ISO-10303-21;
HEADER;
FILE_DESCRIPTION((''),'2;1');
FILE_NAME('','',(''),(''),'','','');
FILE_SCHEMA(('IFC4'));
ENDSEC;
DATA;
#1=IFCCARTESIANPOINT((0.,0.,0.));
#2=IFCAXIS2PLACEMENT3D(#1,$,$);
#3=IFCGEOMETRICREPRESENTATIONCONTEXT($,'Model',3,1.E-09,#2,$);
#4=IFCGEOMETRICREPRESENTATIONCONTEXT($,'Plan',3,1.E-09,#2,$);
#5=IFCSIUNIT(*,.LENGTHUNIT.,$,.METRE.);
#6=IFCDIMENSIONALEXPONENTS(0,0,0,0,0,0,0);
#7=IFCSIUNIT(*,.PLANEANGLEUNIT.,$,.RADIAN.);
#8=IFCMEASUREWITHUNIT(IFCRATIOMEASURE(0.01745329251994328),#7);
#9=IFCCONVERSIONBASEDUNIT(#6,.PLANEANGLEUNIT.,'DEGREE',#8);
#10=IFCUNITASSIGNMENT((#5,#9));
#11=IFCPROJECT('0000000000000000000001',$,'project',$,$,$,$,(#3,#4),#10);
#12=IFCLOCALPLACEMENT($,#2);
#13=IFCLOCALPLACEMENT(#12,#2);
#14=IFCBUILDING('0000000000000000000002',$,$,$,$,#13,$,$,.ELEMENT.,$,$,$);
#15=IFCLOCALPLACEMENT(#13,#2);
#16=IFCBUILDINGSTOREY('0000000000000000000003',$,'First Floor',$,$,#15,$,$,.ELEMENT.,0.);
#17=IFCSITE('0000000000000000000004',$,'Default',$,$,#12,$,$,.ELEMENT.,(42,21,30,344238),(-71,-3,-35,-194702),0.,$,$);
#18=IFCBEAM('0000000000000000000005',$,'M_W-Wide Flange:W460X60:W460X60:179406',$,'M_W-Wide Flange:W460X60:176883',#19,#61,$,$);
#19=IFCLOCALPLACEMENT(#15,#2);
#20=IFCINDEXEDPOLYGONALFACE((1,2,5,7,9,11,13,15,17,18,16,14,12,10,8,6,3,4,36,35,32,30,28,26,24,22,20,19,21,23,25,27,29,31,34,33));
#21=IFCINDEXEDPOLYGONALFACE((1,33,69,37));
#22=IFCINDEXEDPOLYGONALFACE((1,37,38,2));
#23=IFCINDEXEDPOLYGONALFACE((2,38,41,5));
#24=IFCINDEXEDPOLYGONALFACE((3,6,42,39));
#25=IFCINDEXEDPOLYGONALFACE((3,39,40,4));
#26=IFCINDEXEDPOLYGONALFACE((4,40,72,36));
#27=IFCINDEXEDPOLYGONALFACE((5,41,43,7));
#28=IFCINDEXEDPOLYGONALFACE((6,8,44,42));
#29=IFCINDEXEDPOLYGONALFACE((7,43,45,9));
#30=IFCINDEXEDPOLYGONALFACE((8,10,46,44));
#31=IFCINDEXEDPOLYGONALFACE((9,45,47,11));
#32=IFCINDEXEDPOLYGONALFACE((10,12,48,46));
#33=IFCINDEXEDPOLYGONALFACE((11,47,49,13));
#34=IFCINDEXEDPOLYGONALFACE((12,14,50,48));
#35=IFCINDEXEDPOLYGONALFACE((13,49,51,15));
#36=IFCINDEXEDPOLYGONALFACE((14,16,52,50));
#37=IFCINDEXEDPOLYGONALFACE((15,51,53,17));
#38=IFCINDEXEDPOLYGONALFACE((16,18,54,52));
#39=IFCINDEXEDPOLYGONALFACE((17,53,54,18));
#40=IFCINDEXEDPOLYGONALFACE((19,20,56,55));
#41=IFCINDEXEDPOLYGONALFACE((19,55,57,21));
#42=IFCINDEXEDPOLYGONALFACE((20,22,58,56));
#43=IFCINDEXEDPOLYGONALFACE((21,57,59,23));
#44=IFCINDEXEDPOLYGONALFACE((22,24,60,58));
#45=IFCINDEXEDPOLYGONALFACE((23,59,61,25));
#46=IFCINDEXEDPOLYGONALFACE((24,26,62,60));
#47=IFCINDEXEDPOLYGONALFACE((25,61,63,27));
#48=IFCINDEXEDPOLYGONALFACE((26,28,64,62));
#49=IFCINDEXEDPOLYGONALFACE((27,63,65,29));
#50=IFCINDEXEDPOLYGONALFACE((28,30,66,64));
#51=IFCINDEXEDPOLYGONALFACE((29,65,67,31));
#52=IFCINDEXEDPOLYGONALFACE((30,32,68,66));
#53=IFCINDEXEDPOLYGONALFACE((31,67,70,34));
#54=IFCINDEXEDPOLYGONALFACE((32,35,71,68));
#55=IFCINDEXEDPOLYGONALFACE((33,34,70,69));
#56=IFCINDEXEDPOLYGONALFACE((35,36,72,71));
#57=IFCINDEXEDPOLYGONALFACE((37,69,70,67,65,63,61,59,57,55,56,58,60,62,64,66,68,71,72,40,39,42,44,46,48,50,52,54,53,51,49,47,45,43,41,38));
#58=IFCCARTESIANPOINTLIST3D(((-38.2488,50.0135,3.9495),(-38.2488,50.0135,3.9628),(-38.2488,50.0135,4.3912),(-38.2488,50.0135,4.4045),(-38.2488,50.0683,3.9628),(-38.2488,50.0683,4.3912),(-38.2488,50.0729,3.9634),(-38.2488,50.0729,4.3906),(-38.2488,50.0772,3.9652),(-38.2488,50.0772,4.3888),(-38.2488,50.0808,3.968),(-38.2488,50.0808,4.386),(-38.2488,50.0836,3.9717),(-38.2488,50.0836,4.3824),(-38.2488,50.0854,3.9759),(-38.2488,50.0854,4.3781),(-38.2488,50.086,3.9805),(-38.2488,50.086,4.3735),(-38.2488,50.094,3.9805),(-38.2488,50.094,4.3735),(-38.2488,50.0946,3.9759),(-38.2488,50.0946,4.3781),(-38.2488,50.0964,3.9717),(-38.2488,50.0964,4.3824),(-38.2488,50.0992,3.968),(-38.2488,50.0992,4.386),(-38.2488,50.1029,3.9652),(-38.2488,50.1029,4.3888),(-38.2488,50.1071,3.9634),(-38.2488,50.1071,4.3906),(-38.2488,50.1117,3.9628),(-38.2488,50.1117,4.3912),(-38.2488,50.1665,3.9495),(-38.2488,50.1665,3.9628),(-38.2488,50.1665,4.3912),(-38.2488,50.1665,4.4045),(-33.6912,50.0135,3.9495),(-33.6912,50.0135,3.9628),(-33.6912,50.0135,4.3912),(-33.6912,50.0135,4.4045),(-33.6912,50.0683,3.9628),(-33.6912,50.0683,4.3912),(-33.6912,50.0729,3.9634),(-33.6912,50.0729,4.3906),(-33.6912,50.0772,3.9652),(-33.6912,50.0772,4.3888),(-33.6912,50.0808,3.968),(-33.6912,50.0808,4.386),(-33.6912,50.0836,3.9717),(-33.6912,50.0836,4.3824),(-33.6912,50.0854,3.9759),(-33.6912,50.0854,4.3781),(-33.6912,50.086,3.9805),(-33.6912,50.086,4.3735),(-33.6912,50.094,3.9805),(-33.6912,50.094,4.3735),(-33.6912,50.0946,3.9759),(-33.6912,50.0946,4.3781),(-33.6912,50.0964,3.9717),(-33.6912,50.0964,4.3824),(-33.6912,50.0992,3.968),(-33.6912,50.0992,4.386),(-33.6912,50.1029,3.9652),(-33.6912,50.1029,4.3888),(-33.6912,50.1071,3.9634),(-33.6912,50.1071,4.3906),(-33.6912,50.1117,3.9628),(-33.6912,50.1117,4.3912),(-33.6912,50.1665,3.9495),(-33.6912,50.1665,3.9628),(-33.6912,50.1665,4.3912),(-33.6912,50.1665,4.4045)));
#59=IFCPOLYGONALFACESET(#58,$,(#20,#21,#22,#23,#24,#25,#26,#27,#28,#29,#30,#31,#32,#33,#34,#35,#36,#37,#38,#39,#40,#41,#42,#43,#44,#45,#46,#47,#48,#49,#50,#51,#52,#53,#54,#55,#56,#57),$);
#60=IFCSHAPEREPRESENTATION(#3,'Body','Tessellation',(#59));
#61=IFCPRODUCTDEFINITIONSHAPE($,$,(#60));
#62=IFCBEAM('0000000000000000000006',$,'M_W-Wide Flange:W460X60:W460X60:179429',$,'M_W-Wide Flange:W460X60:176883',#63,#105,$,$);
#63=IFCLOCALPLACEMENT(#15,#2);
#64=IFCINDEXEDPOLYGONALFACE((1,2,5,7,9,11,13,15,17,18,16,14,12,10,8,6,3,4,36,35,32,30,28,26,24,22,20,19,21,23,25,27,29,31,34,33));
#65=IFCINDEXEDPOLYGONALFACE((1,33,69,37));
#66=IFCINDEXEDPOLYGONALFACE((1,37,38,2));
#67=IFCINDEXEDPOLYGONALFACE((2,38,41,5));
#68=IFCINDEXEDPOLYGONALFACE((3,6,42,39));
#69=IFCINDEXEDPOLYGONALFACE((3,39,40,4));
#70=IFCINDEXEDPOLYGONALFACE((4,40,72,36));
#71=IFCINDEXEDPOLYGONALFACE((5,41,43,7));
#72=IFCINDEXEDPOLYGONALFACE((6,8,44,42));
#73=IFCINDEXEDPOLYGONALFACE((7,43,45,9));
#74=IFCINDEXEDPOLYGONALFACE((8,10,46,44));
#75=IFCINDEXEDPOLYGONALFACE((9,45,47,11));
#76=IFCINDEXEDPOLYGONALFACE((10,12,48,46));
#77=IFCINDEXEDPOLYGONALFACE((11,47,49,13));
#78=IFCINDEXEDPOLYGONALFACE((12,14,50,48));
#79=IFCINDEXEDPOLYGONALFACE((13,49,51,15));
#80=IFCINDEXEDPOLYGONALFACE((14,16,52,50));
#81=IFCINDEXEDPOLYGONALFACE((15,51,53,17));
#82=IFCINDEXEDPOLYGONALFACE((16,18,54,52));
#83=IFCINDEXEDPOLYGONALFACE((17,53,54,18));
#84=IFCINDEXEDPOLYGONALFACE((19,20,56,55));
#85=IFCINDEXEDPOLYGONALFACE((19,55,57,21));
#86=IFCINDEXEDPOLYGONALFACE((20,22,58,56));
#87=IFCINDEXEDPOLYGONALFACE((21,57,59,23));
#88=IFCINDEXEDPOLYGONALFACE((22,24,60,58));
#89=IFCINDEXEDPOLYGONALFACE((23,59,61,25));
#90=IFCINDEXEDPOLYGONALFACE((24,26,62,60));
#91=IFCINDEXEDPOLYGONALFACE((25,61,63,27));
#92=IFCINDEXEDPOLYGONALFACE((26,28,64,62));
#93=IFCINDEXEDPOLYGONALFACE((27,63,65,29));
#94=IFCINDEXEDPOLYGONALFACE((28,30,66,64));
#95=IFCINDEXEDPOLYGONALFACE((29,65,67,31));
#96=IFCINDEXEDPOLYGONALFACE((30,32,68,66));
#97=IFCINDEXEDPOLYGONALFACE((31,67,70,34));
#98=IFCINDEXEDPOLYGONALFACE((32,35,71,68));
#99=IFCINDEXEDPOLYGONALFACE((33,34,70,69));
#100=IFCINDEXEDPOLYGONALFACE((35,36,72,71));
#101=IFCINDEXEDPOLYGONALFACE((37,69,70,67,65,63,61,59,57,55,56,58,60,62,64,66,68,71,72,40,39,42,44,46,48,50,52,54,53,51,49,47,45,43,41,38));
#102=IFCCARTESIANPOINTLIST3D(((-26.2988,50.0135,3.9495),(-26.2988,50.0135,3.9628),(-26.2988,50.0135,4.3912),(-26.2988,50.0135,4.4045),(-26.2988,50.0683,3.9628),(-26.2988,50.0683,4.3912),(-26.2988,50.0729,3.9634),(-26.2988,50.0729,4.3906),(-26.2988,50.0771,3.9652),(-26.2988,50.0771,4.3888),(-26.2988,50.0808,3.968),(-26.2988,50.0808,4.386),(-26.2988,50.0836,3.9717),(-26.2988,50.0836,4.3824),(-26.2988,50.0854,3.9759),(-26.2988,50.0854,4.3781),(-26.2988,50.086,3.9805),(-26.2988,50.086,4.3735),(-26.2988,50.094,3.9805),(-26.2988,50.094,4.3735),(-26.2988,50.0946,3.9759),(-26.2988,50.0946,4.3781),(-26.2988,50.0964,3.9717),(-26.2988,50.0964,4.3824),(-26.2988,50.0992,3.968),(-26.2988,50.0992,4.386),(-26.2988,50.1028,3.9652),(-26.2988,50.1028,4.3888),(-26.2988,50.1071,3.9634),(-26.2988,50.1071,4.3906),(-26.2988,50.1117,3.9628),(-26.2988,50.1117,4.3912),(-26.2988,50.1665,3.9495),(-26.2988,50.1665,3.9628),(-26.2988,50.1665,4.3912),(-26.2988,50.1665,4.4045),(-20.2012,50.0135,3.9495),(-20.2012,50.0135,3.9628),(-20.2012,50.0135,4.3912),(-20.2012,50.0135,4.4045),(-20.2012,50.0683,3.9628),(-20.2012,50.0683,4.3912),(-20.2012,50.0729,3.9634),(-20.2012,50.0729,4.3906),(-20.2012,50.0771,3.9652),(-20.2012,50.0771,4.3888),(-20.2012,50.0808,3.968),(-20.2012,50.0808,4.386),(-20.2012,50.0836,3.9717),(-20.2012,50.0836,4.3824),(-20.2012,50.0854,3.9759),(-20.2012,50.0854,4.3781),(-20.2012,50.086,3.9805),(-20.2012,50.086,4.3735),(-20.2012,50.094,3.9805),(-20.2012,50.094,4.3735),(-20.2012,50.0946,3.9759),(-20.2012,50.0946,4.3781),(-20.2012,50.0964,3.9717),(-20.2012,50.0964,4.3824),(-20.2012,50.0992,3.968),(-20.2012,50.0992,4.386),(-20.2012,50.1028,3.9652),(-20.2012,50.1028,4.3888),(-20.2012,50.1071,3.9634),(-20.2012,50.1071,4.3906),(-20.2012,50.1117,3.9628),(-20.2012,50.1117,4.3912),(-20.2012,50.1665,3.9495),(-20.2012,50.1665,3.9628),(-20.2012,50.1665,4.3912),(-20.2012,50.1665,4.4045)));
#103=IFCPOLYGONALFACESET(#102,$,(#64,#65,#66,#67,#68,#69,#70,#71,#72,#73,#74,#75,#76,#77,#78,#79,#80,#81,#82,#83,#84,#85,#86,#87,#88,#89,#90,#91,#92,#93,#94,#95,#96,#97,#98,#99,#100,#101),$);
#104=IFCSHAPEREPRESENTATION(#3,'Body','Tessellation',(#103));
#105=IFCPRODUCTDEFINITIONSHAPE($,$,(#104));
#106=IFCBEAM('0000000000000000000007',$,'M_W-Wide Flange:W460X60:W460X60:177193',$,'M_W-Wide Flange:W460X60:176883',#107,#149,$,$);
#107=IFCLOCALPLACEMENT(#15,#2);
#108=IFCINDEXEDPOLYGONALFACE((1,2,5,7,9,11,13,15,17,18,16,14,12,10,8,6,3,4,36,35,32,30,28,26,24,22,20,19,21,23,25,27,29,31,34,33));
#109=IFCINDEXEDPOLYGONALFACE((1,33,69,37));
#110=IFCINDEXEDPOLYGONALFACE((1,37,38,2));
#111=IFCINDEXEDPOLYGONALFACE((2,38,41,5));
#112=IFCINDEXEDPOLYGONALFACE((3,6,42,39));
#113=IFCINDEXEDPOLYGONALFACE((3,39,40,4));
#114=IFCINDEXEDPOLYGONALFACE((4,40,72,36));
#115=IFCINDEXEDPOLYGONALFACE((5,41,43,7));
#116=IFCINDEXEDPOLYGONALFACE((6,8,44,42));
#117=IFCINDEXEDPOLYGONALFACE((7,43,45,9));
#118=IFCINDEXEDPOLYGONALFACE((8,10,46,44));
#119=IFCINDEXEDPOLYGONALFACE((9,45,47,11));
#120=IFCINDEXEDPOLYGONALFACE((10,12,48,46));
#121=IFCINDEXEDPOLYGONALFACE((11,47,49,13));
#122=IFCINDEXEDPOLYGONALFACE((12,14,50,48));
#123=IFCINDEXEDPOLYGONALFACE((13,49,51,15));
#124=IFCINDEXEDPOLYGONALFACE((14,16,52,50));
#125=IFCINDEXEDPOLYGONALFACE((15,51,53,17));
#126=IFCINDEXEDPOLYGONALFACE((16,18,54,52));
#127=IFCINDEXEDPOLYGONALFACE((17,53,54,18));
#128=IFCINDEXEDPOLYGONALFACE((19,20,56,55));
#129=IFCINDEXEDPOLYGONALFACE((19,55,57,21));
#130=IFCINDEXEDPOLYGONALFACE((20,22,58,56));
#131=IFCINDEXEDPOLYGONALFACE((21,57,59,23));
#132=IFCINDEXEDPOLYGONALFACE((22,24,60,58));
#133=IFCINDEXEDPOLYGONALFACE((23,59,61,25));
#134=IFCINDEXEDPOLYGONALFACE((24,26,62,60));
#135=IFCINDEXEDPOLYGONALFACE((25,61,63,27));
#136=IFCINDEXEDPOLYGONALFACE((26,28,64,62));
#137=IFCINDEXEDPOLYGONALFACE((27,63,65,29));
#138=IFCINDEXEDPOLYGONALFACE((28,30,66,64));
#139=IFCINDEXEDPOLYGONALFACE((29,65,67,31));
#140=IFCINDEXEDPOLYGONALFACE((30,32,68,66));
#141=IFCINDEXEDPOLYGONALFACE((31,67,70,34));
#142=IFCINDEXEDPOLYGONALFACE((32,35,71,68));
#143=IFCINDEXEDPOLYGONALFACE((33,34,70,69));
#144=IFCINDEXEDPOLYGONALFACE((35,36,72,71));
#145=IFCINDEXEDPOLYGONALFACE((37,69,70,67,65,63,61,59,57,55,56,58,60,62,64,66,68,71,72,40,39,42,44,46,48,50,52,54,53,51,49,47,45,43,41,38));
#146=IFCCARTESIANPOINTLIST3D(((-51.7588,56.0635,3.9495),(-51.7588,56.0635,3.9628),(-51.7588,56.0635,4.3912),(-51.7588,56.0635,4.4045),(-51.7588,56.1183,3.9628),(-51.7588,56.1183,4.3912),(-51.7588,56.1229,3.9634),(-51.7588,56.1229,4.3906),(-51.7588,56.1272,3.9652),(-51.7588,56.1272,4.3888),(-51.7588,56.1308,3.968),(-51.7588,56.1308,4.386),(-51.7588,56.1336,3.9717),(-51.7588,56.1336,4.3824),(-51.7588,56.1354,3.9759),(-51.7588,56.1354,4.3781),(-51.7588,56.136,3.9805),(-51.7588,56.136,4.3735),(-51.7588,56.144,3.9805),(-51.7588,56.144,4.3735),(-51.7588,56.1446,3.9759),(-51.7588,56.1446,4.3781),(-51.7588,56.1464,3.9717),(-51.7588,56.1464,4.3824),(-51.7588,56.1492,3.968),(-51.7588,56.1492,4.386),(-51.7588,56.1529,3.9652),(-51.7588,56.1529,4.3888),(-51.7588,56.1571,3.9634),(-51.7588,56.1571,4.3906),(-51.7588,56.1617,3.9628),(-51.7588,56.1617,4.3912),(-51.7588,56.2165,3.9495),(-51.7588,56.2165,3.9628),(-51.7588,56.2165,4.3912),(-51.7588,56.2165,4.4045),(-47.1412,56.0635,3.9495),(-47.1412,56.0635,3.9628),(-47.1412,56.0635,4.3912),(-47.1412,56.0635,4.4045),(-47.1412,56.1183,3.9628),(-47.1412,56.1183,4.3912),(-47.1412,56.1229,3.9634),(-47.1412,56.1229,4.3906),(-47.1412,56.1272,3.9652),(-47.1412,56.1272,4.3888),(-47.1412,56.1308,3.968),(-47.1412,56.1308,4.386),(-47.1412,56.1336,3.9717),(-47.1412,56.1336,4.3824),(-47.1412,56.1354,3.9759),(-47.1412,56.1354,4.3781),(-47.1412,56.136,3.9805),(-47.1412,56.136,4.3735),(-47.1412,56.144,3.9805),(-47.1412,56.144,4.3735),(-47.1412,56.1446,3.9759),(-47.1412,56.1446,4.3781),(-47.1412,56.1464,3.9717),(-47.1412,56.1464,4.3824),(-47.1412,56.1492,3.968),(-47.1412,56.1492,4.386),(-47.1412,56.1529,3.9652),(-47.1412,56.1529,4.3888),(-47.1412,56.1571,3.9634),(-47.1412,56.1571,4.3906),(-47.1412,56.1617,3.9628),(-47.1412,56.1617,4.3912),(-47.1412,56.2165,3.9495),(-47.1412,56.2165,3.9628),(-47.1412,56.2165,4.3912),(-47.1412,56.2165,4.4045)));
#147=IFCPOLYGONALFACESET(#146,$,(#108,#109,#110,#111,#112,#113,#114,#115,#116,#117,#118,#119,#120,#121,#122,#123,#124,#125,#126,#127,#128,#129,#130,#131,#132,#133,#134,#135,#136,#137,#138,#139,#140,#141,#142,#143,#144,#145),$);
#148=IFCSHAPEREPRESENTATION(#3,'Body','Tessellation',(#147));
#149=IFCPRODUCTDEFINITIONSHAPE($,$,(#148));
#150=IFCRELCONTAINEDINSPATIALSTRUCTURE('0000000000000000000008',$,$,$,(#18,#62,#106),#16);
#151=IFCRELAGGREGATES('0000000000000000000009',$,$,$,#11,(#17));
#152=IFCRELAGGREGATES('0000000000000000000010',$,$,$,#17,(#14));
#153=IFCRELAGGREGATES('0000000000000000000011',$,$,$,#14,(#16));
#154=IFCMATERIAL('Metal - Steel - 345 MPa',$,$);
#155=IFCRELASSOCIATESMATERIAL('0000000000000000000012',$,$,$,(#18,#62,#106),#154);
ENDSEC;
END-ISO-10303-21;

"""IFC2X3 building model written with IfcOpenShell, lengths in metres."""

from ifc_helpers import new_model, entity, si_unit, converted_unit, frame, frame_2d, origin, place, context, project, spatial, polyline, circle_curve, parameter, trimmed, segment, composite_curve, outline, extrude, material, element, save


model = new_model("IFC2X3")

# Units and contexts
model_context = context("Model", 3, precision=1e-09, world=origin())
plan_context = context("Plan", 3, precision=1e-09, world=origin())
ifc_project = project(units=[si_unit("LENGTHUNIT", "METRE"), converted_unit("PLANEANGLEUNIT", "DEGREE", entity("IfcRatioMeasure", 0.01745329251994328), si_unit("PLANEANGLEUNIT", "RADIAN"), dimensions=[0, 0, 0, 0, 0, 0, 0])], contexts=[model_context, plan_context])

# Site, building, storey
site_placement = place(None, origin())
site = spatial("IfcSite", under=ifc_project, at=site_placement, Name="Default", CompositionType="ELEMENT", RefLatitude=(42, 21, 30, 344238), RefLongitude=(-71, -3, -35, -194702), RefElevation=0.0)
building_placement = place(site_placement, origin())
building = spatial("IfcBuilding", under=site, at=building_placement, CompositionType="ELEMENT")
storey_placement = place(building_placement, origin())
storey = spatial("IfcBuildingStorey", under=building, at=storey_placement, Name="First Floor", CompositionType="ELEMENT", Elevation=0.0)

# Beams
ifc_material = material(Name="Metal - Steel - 345 MPa")
beam_1_placement = place(storey_placement, frame((-38.3928, 50.09, 4.4045), z_axis=(0.0, 0.0, 1.0), x_axis=(0.0, -1.0, 0.0)))
element("IfcBeam", 1, at=beam_1_placement, inside=storey, material=ifc_material, Name="M_W-Wide Flange:W460X60:W460X60:179406", ObjectType="M_W-Wide Flange:W460X60:176883", context=model_context, shape_type="SweptSolid", body=[
    extrude(outline(composite_curve([segment(polyline([(-0.0765, -0.2142), (-0.0765, -0.2275)]), True, "CONTINUOUS"), segment(polyline([(-0.0765, -0.2275), (0.0765, -0.2275)]), True, "CONTINUOUS"), segment(polyline([(0.0765, -0.2275), (0.0765, -0.2142)]), True, "CONTINUOUS"), segment(polyline([(0.0765, -0.2142), (0.0217, -0.2142)]), True, "CONTINUOUS"), segment(trimmed(circle_curve(frame_2d((0.0217, -0.1965), x_axis=(0.0, -1.0)), 0.0177), [parameter(270.0)], [parameter(360.0)], True, "PARAMETER"), False, "CONTINUOUS"), segment(polyline([(0.004, -0.1965), (0.004, 0.1965)]), True, "CONTINUOUS"), segment(trimmed(circle_curve(frame_2d((0.0217, 0.1965), x_axis=(-1.0, 0.0)), 0.0177), [parameter(270.0)], [parameter(360.0)], True, "PARAMETER"), False, "CONTINUOUS"), segment(polyline([(0.0217, 0.2142), (0.0765, 0.2142)]), True, "CONTINUOUS"), segment(polyline([(0.0765, 0.2142), (0.0765, 0.2275)]), True, "CONTINUOUS"), segment(polyline([(0.0765, 0.2275), (-0.0765, 0.2275)]), True, "CONTINUOUS"), segment(polyline([(-0.0765, 0.2275), (-0.0765, 0.2142)]), True, "CONTINUOUS"), segment(polyline([(-0.0765, 0.2142), (-0.0217, 0.2142)]), True, "CONTINUOUS"), segment(trimmed(circle_curve(frame_2d((-0.0217, 0.1965), x_axis=(0.0, 1.0)), 0.0177), [parameter(270.0)], [parameter(360.0)], True, "PARAMETER"), False, "CONTINUOUS"), segment(polyline([(-0.004, 0.1965), (-0.004, -0.1965)]), True, "CONTINUOUS"), segment(trimmed(circle_curve(frame_2d((-0.0217, -0.1965), x_axis=(1.0, 0.0)), 0.0177), [parameter(270.0)], [parameter(0.0)], True, "PARAMETER"), False, "CONTINUOUS"), segment(polyline([(-0.0217, -0.2142), (-0.0765, -0.2142)]), True, "CONTINUOUS")], self_intersect=False)), frame((0.0, 0.144, -0.2275), z_axis=(0.0, -1.0, 0.0), x_axis=(1.0, 0.0, 0.0)), (0.0, 0.0, -1.0), 4.5576),
])
beam_2_placement = place(storey_placement, frame((-26.4421, 50.09, 4.4045), z_axis=(0.0, 0.0, 1.0), x_axis=(0.0, -1.0, 0.0)))
element("IfcBeam", 2, at=beam_2_placement, inside=storey, material=ifc_material, Name="M_W-Wide Flange:W460X60:W460X60:179429", ObjectType="M_W-Wide Flange:W460X60:176883", context=model_context, shape_type="SweptSolid", body=[
    extrude(outline(composite_curve([segment(polyline([(-0.0765, -0.2142), (-0.0765, -0.2275)]), True, "CONTINUOUS"), segment(polyline([(-0.0765, -0.2275), (0.0765, -0.2275)]), True, "CONTINUOUS"), segment(polyline([(0.0765, -0.2275), (0.0765, -0.2142)]), True, "CONTINUOUS"), segment(polyline([(0.0765, -0.2142), (0.0217, -0.2142)]), True, "CONTINUOUS"), segment(trimmed(circle_curve(frame_2d((0.0217, -0.1965), x_axis=(0.0, -1.0)), 0.0177), [parameter(270.0)], [parameter(360.0)], True, "PARAMETER"), False, "CONTINUOUS"), segment(polyline([(0.004, -0.1965), (0.004, 0.1965)]), True, "CONTINUOUS"), segment(trimmed(circle_curve(frame_2d((0.0217, 0.1965), x_axis=(-1.0, 0.0)), 0.0177), [parameter(270.0)], [parameter(360.0)], True, "PARAMETER"), False, "CONTINUOUS"), segment(polyline([(0.0217, 0.2142), (0.0765, 0.2142)]), True, "CONTINUOUS"), segment(polyline([(0.0765, 0.2142), (0.0765, 0.2275)]), True, "CONTINUOUS"), segment(polyline([(0.0765, 0.2275), (-0.0765, 0.2275)]), True, "CONTINUOUS"), segment(polyline([(-0.0765, 0.2275), (-0.0765, 0.2142)]), True, "CONTINUOUS"), segment(polyline([(-0.0765, 0.2142), (-0.0217, 0.2142)]), True, "CONTINUOUS"), segment(trimmed(circle_curve(frame_2d((-0.0217, 0.1965), x_axis=(0.0, 1.0)), 0.0177), [parameter(270.0)], [parameter(360.0)], True, "PARAMETER"), False, "CONTINUOUS"), segment(polyline([(-0.004, 0.1965), (-0.004, -0.1965)]), True, "CONTINUOUS"), segment(trimmed(circle_curve(frame_2d((-0.0217, -0.1965), x_axis=(1.0, 0.0)), 0.0177), [parameter(270.0)], [parameter(0.0)], True, "PARAMETER"), False, "CONTINUOUS"), segment(polyline([(-0.0217, -0.2142), (-0.0765, -0.2142)]), True, "CONTINUOUS")], self_intersect=False)), frame((0.0, 0.1433, -0.2275), z_axis=(0.0, -1.0, 0.0), x_axis=(1.0, 0.0, 0.0)), (0.0, 0.0, -1.0), 6.0976),
])
beam_3_placement = place(storey_placement, frame((-51.8972, 56.14, 4.4045), z_axis=(0.0, 0.0, 1.0), x_axis=(0.0, -1.0, 0.0)))
element("IfcBeam", 3, at=beam_3_placement, inside=storey, material=ifc_material, Name="M_W-Wide Flange:W460X60:W460X60:177193", ObjectType="M_W-Wide Flange:W460X60:176883", context=model_context, shape_type="SweptSolid", body=[
    extrude(outline(composite_curve([segment(polyline([(-0.0765, -0.2142), (-0.0765, -0.2275)]), True, "CONTINUOUS"), segment(polyline([(-0.0765, -0.2275), (0.0765, -0.2275)]), True, "CONTINUOUS"), segment(polyline([(0.0765, -0.2275), (0.0765, -0.2142)]), True, "CONTINUOUS"), segment(polyline([(0.0765, -0.2142), (0.0217, -0.2142)]), True, "CONTINUOUS"), segment(trimmed(circle_curve(frame_2d((0.0217, -0.1965), x_axis=(1.0, 0.0)), 0.0177), [parameter(180.0)], [parameter(270.0)], True, "PARAMETER"), False, "CONTINUOUS"), segment(polyline([(0.004, -0.1965), (0.004, 0.1965)]), True, "CONTINUOUS"), segment(trimmed(circle_curve(frame_2d((0.0217, 0.1965), x_axis=(1.0, 0.0)), 0.0177), [parameter(90.0)], [parameter(180.0)], True, "PARAMETER"), False, "CONTINUOUS"), segment(polyline([(0.0217, 0.2142), (0.0765, 0.2142)]), True, "CONTINUOUS"), segment(polyline([(0.0765, 0.2142), (0.0765, 0.2275)]), True, "CONTINUOUS"), segment(polyline([(0.0765, 0.2275), (-0.0765, 0.2275)]), True, "CONTINUOUS"), segment(polyline([(-0.0765, 0.2275), (-0.0765, 0.2142)]), True, "CONTINUOUS"), segment(polyline([(-0.0765, 0.2142), (-0.0217, 0.2142)]), True, "CONTINUOUS"), segment(trimmed(circle_curve(frame_2d((-0.0217, 0.1965), x_axis=(1.0, 0.0)), 0.0177), [parameter(360.0)], [parameter(90.0)], True, "PARAMETER"), False, "CONTINUOUS"), segment(polyline([(-0.004, 0.1965), (-0.004, -0.1965)]), True, "CONTINUOUS"), segment(trimmed(circle_curve(frame_2d((-0.0217, -0.1965), x_axis=(1.0, 0.0)), 0.0177), [parameter(270.0)], [parameter(0.0)], True, "PARAMETER"), False, "CONTINUOUS"), segment(polyline([(-0.0217, -0.2142), (-0.0765, -0.2142)]), True, "CONTINUOUS")], self_intersect=False)), frame((0.0, 0.1384, -0.2275), z_axis=(0.0, -1.0, 0.0), x_axis=(1.0, 0.0, 0.0)), (0.0, 0.0, -1.0), 4.6176),
])

save(model, "model.ifc")
